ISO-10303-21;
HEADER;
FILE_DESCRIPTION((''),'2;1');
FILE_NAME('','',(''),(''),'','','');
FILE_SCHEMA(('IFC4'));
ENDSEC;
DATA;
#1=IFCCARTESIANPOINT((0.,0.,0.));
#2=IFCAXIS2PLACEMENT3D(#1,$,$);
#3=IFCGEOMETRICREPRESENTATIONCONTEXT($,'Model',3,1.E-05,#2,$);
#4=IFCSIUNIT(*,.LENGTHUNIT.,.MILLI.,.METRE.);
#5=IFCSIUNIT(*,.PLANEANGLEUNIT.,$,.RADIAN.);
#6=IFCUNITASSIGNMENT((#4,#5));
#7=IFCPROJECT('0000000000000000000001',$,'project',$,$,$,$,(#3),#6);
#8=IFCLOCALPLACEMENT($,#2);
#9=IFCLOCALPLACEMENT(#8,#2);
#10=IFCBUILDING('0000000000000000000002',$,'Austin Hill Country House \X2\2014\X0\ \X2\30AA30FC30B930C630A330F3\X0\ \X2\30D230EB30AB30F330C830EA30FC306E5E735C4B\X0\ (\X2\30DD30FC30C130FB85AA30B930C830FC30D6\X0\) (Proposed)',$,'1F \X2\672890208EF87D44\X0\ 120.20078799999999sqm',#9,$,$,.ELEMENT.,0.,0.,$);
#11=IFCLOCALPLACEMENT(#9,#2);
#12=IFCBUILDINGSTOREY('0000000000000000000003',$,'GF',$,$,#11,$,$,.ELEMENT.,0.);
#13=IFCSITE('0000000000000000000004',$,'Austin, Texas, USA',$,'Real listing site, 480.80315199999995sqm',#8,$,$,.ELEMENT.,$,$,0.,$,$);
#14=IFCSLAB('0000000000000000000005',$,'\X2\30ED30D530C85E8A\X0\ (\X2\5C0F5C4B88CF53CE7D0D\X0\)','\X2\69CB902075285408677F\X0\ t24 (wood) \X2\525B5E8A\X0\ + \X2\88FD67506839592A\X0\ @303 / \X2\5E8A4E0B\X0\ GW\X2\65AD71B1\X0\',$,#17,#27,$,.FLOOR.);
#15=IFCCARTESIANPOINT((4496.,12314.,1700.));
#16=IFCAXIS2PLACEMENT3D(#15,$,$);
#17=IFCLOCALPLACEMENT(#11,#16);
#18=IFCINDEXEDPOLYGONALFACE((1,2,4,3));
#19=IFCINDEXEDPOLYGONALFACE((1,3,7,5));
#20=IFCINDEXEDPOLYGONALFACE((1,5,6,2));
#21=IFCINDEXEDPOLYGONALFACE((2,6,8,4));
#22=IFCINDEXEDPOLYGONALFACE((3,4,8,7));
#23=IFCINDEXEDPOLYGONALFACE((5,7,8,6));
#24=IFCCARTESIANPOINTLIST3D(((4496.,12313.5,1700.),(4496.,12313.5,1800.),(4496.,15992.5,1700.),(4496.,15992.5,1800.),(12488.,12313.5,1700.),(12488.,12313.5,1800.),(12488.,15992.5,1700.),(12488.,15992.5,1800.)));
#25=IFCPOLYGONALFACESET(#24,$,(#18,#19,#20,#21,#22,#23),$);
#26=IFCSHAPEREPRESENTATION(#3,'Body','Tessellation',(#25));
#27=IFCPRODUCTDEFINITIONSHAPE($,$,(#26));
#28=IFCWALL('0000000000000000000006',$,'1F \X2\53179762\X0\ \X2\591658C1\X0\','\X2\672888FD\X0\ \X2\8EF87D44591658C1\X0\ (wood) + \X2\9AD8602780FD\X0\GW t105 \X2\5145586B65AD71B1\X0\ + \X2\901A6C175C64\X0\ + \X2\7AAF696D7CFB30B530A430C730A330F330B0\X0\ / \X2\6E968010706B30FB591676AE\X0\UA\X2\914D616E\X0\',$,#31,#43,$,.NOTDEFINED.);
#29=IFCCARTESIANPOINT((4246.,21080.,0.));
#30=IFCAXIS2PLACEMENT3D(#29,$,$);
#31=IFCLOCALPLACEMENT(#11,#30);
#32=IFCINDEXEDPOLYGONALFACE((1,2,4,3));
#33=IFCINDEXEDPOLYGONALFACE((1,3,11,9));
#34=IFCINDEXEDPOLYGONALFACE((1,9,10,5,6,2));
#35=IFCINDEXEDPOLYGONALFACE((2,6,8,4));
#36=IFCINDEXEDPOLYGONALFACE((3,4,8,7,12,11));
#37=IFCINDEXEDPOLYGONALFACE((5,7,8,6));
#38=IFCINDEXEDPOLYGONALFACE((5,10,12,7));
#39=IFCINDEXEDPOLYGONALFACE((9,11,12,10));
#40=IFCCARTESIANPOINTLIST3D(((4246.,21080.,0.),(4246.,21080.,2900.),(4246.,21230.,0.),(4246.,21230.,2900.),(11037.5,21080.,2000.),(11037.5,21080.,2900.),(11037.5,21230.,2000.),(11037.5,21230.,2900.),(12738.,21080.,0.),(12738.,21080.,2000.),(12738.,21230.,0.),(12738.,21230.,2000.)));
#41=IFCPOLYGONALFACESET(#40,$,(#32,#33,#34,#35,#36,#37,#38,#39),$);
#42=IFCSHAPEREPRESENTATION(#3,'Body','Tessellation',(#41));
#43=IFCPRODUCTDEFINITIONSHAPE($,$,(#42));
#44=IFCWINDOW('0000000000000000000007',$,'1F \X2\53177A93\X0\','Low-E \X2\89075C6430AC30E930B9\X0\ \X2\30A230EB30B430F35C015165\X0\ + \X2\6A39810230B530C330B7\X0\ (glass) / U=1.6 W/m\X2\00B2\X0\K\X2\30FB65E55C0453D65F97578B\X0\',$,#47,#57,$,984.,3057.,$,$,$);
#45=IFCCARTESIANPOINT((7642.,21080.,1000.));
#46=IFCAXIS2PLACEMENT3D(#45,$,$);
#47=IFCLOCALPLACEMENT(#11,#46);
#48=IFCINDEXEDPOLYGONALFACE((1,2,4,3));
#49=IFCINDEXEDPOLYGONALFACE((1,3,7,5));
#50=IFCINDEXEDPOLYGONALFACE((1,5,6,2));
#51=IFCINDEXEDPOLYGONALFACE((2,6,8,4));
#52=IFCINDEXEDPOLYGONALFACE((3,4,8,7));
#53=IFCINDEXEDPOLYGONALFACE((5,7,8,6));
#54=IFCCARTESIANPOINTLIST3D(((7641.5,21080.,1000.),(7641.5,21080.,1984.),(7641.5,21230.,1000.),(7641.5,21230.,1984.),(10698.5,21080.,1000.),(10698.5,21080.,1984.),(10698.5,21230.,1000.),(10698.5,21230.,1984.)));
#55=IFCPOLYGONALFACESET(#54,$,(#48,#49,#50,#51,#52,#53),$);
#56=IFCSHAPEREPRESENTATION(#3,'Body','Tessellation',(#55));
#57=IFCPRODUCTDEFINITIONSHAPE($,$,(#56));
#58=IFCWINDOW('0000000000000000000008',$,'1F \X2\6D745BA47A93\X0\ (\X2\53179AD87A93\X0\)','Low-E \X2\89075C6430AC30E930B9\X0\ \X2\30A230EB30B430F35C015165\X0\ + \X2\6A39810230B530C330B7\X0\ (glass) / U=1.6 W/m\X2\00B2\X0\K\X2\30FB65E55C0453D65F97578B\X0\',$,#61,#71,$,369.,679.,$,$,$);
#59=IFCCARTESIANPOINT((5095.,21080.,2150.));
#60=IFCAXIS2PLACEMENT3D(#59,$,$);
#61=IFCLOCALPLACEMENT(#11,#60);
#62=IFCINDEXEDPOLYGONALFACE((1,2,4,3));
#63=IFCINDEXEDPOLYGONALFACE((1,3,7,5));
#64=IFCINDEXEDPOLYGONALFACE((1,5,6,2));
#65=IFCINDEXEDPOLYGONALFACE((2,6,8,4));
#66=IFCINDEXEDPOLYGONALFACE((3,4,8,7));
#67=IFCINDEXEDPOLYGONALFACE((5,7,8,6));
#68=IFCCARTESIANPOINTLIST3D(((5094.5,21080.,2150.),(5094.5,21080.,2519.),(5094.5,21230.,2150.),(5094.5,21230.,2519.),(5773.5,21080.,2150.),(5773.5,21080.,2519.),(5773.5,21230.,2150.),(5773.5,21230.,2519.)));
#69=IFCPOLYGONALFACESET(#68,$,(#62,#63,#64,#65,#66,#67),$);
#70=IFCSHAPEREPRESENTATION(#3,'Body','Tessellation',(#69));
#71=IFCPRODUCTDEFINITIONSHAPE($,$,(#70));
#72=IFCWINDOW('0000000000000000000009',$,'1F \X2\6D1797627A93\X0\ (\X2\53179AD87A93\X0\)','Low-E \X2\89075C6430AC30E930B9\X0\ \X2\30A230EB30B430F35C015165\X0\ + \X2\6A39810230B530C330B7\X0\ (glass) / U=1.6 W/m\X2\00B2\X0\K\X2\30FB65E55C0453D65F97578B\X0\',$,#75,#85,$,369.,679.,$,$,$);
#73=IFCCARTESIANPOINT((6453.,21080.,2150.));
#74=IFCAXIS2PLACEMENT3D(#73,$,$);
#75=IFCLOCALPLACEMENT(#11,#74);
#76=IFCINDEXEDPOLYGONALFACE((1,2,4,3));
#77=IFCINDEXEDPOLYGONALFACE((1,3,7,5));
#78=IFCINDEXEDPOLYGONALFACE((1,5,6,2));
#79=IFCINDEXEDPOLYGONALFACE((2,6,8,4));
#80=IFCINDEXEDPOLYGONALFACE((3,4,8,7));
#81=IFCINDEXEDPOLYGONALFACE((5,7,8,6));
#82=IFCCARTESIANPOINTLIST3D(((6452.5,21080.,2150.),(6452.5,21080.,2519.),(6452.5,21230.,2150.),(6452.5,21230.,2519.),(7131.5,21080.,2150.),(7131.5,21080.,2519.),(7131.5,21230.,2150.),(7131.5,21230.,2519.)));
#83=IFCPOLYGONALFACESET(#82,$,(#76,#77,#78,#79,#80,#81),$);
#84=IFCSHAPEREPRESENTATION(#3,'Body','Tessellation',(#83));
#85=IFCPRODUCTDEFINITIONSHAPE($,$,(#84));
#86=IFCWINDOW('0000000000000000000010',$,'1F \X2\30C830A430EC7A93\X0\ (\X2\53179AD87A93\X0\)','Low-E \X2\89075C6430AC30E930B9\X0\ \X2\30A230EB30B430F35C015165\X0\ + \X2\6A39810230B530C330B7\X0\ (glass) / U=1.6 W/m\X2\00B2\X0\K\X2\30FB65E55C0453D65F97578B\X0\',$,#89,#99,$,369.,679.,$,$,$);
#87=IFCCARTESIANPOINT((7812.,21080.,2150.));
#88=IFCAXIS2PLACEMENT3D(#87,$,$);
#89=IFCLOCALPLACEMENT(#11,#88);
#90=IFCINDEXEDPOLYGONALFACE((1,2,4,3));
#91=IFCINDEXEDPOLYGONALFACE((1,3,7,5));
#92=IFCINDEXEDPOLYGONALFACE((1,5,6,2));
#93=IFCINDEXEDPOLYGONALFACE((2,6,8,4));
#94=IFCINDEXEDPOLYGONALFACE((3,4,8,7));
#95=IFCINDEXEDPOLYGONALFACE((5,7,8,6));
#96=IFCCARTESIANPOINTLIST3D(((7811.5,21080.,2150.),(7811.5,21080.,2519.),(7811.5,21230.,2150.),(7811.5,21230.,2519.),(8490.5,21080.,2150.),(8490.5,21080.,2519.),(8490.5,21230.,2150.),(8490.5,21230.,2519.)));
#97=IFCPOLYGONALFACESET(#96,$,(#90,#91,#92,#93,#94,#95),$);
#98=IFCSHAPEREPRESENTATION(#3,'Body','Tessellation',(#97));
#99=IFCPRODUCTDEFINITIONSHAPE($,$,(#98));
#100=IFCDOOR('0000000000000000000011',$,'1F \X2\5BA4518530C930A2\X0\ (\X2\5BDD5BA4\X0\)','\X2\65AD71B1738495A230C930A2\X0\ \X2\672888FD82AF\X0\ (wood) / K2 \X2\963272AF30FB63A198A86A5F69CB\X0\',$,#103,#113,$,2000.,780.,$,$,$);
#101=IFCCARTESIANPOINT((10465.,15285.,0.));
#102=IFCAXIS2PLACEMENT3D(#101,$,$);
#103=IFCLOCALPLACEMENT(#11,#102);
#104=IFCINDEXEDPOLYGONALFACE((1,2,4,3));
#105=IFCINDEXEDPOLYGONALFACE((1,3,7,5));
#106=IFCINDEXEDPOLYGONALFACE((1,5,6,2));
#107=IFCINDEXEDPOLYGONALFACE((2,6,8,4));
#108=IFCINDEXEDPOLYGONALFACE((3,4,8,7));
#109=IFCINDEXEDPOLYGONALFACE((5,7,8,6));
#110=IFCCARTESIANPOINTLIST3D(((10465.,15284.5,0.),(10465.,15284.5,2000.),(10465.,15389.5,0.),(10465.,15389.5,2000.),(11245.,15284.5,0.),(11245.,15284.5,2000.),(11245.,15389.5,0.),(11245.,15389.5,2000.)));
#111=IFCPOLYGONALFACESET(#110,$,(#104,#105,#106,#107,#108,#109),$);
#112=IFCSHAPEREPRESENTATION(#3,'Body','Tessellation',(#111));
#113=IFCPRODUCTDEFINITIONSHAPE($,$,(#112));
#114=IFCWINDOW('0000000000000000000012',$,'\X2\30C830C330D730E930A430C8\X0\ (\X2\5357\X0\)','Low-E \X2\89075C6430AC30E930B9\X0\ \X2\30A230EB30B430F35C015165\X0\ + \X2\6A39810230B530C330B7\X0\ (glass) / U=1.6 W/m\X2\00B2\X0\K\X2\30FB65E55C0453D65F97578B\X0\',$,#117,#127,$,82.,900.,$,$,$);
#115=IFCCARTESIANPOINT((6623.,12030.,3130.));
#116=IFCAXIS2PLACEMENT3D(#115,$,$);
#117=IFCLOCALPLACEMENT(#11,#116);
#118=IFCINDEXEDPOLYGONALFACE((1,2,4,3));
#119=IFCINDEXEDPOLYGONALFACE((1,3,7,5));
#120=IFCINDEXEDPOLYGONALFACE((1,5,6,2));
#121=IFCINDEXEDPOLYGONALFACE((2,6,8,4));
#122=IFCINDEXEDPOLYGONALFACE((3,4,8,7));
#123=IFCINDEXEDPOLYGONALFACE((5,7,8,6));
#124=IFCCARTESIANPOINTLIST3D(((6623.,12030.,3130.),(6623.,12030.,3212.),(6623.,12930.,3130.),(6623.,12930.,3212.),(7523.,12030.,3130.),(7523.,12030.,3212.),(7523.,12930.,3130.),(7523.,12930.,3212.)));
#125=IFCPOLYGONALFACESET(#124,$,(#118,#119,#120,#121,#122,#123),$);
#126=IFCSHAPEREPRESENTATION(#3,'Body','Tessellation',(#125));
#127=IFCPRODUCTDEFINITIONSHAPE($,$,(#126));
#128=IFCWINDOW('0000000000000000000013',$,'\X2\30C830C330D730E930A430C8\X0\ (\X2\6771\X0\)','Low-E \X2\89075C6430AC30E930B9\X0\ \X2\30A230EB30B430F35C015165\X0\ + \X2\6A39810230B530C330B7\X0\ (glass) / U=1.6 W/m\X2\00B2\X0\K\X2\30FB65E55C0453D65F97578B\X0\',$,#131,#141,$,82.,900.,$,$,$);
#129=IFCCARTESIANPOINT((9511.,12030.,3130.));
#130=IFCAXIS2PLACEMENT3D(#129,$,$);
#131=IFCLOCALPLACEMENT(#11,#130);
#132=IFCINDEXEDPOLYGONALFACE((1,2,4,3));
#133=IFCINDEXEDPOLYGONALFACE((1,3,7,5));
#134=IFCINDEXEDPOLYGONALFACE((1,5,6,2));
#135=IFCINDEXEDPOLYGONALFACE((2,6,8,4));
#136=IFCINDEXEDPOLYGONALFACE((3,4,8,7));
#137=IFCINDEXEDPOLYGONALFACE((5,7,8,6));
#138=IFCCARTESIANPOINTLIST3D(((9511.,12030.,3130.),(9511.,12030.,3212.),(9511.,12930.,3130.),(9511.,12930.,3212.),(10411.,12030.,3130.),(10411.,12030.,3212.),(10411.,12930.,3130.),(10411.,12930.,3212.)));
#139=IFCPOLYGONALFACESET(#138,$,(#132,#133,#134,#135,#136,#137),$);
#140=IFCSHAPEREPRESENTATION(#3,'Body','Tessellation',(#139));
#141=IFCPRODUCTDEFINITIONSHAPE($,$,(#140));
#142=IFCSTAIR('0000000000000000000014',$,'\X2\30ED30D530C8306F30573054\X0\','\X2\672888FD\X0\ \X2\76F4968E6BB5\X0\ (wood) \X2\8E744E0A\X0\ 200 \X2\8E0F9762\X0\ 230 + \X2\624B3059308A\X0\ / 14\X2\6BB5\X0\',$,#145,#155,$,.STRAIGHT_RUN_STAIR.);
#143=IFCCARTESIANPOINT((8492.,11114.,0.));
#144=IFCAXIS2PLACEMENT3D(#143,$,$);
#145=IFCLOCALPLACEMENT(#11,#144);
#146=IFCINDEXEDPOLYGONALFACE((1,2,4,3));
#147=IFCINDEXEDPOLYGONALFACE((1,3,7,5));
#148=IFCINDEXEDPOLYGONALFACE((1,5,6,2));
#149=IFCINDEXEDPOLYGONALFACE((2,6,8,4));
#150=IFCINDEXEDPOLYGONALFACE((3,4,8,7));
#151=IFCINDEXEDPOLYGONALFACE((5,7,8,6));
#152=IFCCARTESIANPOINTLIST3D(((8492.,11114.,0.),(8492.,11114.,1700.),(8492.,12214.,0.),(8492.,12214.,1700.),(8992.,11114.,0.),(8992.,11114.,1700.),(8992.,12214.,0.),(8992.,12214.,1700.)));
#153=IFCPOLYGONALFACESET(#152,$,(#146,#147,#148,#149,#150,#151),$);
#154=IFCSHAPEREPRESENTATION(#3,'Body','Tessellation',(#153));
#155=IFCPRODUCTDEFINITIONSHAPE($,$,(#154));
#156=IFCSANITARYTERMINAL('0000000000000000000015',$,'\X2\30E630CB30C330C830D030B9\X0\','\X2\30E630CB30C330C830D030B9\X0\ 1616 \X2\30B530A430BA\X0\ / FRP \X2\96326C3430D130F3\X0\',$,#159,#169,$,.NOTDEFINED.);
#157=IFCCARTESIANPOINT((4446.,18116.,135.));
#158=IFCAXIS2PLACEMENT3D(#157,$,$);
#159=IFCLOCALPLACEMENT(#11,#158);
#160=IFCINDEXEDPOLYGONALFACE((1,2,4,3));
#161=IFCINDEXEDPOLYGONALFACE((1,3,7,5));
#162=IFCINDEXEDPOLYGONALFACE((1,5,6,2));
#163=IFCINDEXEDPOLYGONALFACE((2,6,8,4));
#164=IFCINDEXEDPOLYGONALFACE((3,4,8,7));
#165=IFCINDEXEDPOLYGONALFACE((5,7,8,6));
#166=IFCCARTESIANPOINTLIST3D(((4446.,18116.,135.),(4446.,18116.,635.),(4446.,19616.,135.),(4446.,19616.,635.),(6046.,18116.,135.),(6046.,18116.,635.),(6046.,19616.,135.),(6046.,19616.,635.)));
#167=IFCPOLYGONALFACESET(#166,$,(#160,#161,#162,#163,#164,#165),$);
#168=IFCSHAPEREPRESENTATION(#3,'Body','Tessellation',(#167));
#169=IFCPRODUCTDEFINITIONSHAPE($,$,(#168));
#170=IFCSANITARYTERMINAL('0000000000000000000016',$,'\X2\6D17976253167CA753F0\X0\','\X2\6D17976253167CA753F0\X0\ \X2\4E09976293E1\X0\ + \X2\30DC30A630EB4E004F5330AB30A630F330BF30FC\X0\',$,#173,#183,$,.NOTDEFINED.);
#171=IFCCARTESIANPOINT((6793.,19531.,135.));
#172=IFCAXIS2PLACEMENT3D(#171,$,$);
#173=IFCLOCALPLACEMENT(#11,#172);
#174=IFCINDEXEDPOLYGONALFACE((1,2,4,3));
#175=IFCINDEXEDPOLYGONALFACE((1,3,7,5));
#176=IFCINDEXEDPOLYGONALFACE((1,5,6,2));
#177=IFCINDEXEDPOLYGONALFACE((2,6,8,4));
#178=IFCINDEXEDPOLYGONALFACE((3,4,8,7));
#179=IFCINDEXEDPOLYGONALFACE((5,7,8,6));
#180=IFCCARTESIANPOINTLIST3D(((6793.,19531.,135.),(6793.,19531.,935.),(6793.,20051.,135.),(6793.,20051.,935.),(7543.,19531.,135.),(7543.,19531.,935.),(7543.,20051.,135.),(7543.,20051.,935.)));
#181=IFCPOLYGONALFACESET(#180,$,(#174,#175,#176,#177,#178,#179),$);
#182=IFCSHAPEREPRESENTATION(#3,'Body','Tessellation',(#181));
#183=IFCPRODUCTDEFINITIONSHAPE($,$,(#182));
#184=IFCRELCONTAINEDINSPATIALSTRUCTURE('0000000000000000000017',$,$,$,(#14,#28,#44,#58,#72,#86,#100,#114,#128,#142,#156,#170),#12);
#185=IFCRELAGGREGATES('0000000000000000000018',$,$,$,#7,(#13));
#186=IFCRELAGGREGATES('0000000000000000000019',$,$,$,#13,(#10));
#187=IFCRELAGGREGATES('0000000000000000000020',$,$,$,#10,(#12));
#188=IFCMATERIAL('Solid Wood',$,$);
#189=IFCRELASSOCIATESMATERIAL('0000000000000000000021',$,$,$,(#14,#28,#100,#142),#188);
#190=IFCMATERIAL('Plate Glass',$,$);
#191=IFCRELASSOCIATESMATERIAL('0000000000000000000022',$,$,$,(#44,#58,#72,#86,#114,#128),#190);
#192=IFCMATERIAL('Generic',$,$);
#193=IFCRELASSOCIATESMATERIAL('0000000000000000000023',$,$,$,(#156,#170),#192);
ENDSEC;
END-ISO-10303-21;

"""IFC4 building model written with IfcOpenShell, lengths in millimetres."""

from ifc_helpers import new_model, si_unit, frame, frame_2d, origin, place, context, project, spatial, rectangle, extrude, material, element, fill, save


model = new_model("IFC4")

# Units and contexts
model_context = context("Model", 3, precision=1e-05, world=origin())
ifc_project = project(units=[si_unit("LENGTHUNIT", "METRE", prefix="MILLI"), si_unit("PLANEANGLEUNIT", "RADIAN")], contexts=[model_context])

# Site, building, storey
site_placement = place(None, origin())
site = spatial("IfcSite", under=ifc_project, at=site_placement, Name="Austin, Texas, USA", ObjectType="Real listing site, 480.80315199999995sqm", CompositionType="ELEMENT", RefElevation=0.0)
building_placement = place(site_placement, origin())
building = spatial("IfcBuilding", under=site, at=building_placement, Name="Austin Hill Country House — オースティン ヒルカントリーの平屋 (ポーチ・薪ストーブ) (Proposed)", ObjectType="1F 木造軸組 120.20078799999999sqm", CompositionType="ELEMENT", ElevationOfRefHeight=0.0, ElevationOfTerrain=0.0)
storey_placement = place(building_placement, origin())
storey = spatial("IfcBuildingStorey", under=building, at=storey_placement, Name="GF", CompositionType="ELEMENT", Elevation=0.0)

# Slab
ifc_material_1 = material(Name="Solid Wood")
slab_placement = place(storey_placement, frame((4496.0, 12314.0, 1700.0)))
element("IfcSlab", 1, at=slab_placement, inside=storey, material=ifc_material_1, Name="ロフト床 (小屋裏収納)", Description="構造用合板 t24 (wood) 剛床 + 製材根太 @303 / 床下 GW断熱", PredefinedType="FLOOR", context=model_context, shape_type="SweptSolid", body=[
    extrude(rectangle(XDim=7992.0, YDim=3679.0, at=frame_2d((3996.0, 1839.0))), frame((4496.0, 12314.0, 1700.0)), (0.0, 0.0, 1.0), 100.0),
])

# Wall, openings, windows
wall_1_placement = place(storey_placement, frame((4246.0, 21080.0, 0.0)))
wall_1 = element("IfcWall", 2, at=wall_1_placement, inside=storey, material=ifc_material_1, Name="1F 北面 外壁", Description="木製 軸組外壁 (wood) + 高性能GW t105 充填断熱 + 通気層 + 窯業系サイディング / 準耐火・外皮UA配慮", PredefinedType="NOTDEFINED", context=model_context, shape_type="SweptSolid", body=[
    extrude(rectangle(XDim=8492.0, YDim=150.0, at=frame_2d((4246.0, 75.0))), frame((4246.0, 21080.0, 0.0)), (0.0, 0.0, 1.0), 2900.0),
])
opening_1_placement = place(storey_placement, frame((7642.0, 21080.0, 1000.0)))
opening_1 = element("IfcOpeningElement", 3, at=opening_1_placement, cuts=wall_1, PredefinedType="NOTDEFINED", context=model_context, shape_type="SweptSolid", body=[
    extrude(rectangle(XDim=3057.0, YDim=150.0, at=frame_2d((1528.0, 75.0))), frame((7642.0, 21080.0, 1000.0)), (0.0, 0.0, 1.0), 984.0),
])
opening_2_placement = place(storey_placement, frame((5095.0, 21080.0, 2150.0)))
opening_2 = element("IfcOpeningElement", 4, at=opening_2_placement, cuts=wall_1, PredefinedType="NOTDEFINED", context=model_context, shape_type="SweptSolid", body=[
    extrude(rectangle(XDim=679.0, YDim=150.0, at=frame_2d((339.0, 75.0))), frame((5095.0, 21080.0, 2150.0)), (0.0, 0.0, 1.0), 369.0),
])
opening_3_placement = place(storey_placement, frame((6453.0, 21080.0, 2150.0)))
opening_3 = element("IfcOpeningElement", 5, at=opening_3_placement, cuts=wall_1, PredefinedType="NOTDEFINED", context=model_context, shape_type="SweptSolid", body=[
    extrude(rectangle(XDim=679.0, YDim=150.0, at=frame_2d((339.0, 75.0))), frame((6453.0, 21080.0, 2150.0)), (0.0, 0.0, 1.0), 369.0),
])
opening_4_placement = place(storey_placement, frame((7812.0, 21080.0, 2150.0)))
opening_4 = element("IfcOpeningElement", 6, at=opening_4_placement, cuts=wall_1, PredefinedType="NOTDEFINED", context=model_context, shape_type="SweptSolid", body=[
    extrude(rectangle(XDim=679.0, YDim=150.0, at=frame_2d((339.0, 75.0))), frame((7812.0, 21080.0, 2150.0)), (0.0, 0.0, 1.0), 369.0),
])
ifc_material_2 = material(Name="Plate Glass")
window_1_placement = place(storey_placement, frame((7642.0, 21080.0, 1000.0)))
window_1 = element("IfcWindow", 7, at=window_1_placement, inside=storey, material=ifc_material_2, Name="1F 北窓", Description="Low-E 複層ガラス アルゴン封入 + 樹脂サッシ (glass) / U=1.6 W/m²K・日射取得型", OverallHeight=984.0, OverallWidth=3057.0, context=model_context, shape_type="SweptSolid", body=[
    extrude(rectangle(XDim=3057.0, YDim=150.0, at=frame_2d((1528.0, 75.0))), frame((7642.0, 21080.0, 1000.0)), (0.0, 0.0, 1.0), 984.0),
])
fill(opening_1, window_1)
window_2_placement = place(storey_placement, frame((5095.0, 21080.0, 2150.0)))
window_2 = element("IfcWindow", 8, at=window_2_placement, inside=storey, material=ifc_material_2, Name="1F 浴室窓 (北高窓)", Description="Low-E 複層ガラス アルゴン封入 + 樹脂サッシ (glass) / U=1.6 W/m²K・日射取得型", OverallHeight=369.0, OverallWidth=679.0, context=model_context, shape_type="SweptSolid", body=[
    extrude(rectangle(XDim=679.0, YDim=150.0, at=frame_2d((339.0, 75.0))), frame((5095.0, 21080.0, 2150.0)), (0.0, 0.0, 1.0), 369.0),
])
fill(opening_2, window_2)
window_3_placement = place(storey_placement, frame((6453.0, 21080.0, 2150.0)))
window_3 = element("IfcWindow", 9, at=window_3_placement, inside=storey, material=ifc_material_2, Name="1F 洗面窓 (北高窓)", Description="Low-E 複層ガラス アルゴン封入 + 樹脂サッシ (glass) / U=1.6 W/m²K・日射取得型", OverallHeight=369.0, OverallWidth=679.0, context=model_context, shape_type="SweptSolid", body=[
    extrude(rectangle(XDim=679.0, YDim=150.0, at=frame_2d((339.0, 75.0))), frame((6453.0, 21080.0, 2150.0)), (0.0, 0.0, 1.0), 369.0),
])
fill(opening_3, window_3)
window_4_placement = place(storey_placement, frame((7812.0, 21080.0, 2150.0)))
window_4 = element("IfcWindow", 10, at=window_4_placement, inside=storey, material=ifc_material_2, Name="1F トイレ窓 (北高窓)", Description="Low-E 複層ガラス アルゴン封入 + 樹脂サッシ (glass) / U=1.6 W/m²K・日射取得型", OverallHeight=369.0, OverallWidth=679.0, context=model_context, shape_type="SweptSolid", body=[
    extrude(rectangle(XDim=679.0, YDim=150.0, at=frame_2d((339.0, 75.0))), frame((7812.0, 21080.0, 2150.0)), (0.0, 0.0, 1.0), 369.0),
])
fill(opening_4, window_4)

# Door
door_1_placement = place(storey_placement, frame((10465.0, 15285.0, 0.0)))
element("IfcDoor", 11, at=door_1_placement, inside=storey, material=ifc_material_1, Name="1F 室内ドア (寝室)", Description="断熱玄関ドア 木製芯 (wood) / K2 防犯・採風機構", OverallHeight=2000.0, OverallWidth=780.0, context=model_context, shape_type="SweptSolid", body=[
    extrude(rectangle(XDim=780.0, YDim=105.0, at=frame_2d((390.0, 52.0))), frame((10465.0, 15285.0, 0.0)), (0.0, 0.0, 1.0), 2000.0),
])

# Windows
window_5_placement = place(storey_placement, frame((6623.0, 12030.0, 3130.0)))
element("IfcWindow", 12, at=window_5_placement, inside=storey, material=ifc_material_2, Name="トップライト (南)", Description="Low-E 複層ガラス アルゴン封入 + 樹脂サッシ (glass) / U=1.6 W/m²K・日射取得型", OverallHeight=82.0, OverallWidth=900.0, context=model_context, shape_type="SweptSolid", body=[
    extrude(rectangle(XDim=900.0, YDim=900.0, at=frame_2d((450.0, 450.0))), frame((6623.0, 12030.0, 3130.0)), (0.0, 0.0, 1.0), 82.0),
])
window_6_placement = place(storey_placement, frame((9511.0, 12030.0, 3130.0)))
element("IfcWindow", 13, at=window_6_placement, inside=storey, material=ifc_material_2, Name="トップライト (東)", Description="Low-E 複層ガラス アルゴン封入 + 樹脂サッシ (glass) / U=1.6 W/m²K・日射取得型", OverallHeight=82.0, OverallWidth=900.0, context=model_context, shape_type="SweptSolid", body=[
    extrude(rectangle(XDim=900.0, YDim=900.0, at=frame_2d((450.0, 450.0))), frame((9511.0, 12030.0, 3130.0)), (0.0, 0.0, 1.0), 82.0),
])

# Stair
stair_placement = place(storey_placement, frame((8492.0, 11114.0, 0.0)))
element("IfcStair", 14, at=stair_placement, inside=storey, material=ifc_material_1, Name="ロフトはしご", Description="木製 直階段 (wood) 蹴上 200 踏面 230 + 手すり / 14段", PredefinedType="STRAIGHT_RUN_STAIR", context=model_context, shape_type="SweptSolid", body=[
    extrude(rectangle(XDim=500.0, YDim=1100.0, at=frame_2d((250.0, 550.0))), frame((8492.0, 11114.0, 0.0)), (0.0, 0.0, 1.0), 1700.0),
])

# Sanitary terminals
ifc_material_3 = material(Name="Generic")
sanitary_terminal_1_placement = place(storey_placement, frame((4446.0, 18116.0, 135.0)))
element("IfcSanitaryTerminal", 15, at=sanitary_terminal_1_placement, inside=storey, material=ifc_material_3, Name="ユニットバス", Description="ユニットバス 1616 サイズ / FRP 防水パン", PredefinedType="NOTDEFINED", context=model_context, shape_type="SweptSolid", body=[
    extrude(rectangle(XDim=1600.0, YDim=1500.0, at=frame_2d((800.0, 750.0))), frame((4446.0, 18116.0, 135.0)), (0.0, 0.0, 1.0), 500.0),
])
sanitary_terminal_2_placement = place(storey_placement, frame((6793.0, 19531.0, 135.0)))
element("IfcSanitaryTerminal", 16, at=sanitary_terminal_2_placement, inside=storey, material=ifc_material_3, Name="洗面化粧台", Description="洗面化粧台 三面鏡 + ボウル一体カウンター", PredefinedType="NOTDEFINED", context=model_context, shape_type="SweptSolid", body=[
    extrude(rectangle(XDim=750.0, YDim=520.0, at=frame_2d((375.0, 260.0))), frame((6793.0, 19531.0, 135.0)), (0.0, 0.0, 1.0), 800.0),
])

save(model, "model.ifc")
